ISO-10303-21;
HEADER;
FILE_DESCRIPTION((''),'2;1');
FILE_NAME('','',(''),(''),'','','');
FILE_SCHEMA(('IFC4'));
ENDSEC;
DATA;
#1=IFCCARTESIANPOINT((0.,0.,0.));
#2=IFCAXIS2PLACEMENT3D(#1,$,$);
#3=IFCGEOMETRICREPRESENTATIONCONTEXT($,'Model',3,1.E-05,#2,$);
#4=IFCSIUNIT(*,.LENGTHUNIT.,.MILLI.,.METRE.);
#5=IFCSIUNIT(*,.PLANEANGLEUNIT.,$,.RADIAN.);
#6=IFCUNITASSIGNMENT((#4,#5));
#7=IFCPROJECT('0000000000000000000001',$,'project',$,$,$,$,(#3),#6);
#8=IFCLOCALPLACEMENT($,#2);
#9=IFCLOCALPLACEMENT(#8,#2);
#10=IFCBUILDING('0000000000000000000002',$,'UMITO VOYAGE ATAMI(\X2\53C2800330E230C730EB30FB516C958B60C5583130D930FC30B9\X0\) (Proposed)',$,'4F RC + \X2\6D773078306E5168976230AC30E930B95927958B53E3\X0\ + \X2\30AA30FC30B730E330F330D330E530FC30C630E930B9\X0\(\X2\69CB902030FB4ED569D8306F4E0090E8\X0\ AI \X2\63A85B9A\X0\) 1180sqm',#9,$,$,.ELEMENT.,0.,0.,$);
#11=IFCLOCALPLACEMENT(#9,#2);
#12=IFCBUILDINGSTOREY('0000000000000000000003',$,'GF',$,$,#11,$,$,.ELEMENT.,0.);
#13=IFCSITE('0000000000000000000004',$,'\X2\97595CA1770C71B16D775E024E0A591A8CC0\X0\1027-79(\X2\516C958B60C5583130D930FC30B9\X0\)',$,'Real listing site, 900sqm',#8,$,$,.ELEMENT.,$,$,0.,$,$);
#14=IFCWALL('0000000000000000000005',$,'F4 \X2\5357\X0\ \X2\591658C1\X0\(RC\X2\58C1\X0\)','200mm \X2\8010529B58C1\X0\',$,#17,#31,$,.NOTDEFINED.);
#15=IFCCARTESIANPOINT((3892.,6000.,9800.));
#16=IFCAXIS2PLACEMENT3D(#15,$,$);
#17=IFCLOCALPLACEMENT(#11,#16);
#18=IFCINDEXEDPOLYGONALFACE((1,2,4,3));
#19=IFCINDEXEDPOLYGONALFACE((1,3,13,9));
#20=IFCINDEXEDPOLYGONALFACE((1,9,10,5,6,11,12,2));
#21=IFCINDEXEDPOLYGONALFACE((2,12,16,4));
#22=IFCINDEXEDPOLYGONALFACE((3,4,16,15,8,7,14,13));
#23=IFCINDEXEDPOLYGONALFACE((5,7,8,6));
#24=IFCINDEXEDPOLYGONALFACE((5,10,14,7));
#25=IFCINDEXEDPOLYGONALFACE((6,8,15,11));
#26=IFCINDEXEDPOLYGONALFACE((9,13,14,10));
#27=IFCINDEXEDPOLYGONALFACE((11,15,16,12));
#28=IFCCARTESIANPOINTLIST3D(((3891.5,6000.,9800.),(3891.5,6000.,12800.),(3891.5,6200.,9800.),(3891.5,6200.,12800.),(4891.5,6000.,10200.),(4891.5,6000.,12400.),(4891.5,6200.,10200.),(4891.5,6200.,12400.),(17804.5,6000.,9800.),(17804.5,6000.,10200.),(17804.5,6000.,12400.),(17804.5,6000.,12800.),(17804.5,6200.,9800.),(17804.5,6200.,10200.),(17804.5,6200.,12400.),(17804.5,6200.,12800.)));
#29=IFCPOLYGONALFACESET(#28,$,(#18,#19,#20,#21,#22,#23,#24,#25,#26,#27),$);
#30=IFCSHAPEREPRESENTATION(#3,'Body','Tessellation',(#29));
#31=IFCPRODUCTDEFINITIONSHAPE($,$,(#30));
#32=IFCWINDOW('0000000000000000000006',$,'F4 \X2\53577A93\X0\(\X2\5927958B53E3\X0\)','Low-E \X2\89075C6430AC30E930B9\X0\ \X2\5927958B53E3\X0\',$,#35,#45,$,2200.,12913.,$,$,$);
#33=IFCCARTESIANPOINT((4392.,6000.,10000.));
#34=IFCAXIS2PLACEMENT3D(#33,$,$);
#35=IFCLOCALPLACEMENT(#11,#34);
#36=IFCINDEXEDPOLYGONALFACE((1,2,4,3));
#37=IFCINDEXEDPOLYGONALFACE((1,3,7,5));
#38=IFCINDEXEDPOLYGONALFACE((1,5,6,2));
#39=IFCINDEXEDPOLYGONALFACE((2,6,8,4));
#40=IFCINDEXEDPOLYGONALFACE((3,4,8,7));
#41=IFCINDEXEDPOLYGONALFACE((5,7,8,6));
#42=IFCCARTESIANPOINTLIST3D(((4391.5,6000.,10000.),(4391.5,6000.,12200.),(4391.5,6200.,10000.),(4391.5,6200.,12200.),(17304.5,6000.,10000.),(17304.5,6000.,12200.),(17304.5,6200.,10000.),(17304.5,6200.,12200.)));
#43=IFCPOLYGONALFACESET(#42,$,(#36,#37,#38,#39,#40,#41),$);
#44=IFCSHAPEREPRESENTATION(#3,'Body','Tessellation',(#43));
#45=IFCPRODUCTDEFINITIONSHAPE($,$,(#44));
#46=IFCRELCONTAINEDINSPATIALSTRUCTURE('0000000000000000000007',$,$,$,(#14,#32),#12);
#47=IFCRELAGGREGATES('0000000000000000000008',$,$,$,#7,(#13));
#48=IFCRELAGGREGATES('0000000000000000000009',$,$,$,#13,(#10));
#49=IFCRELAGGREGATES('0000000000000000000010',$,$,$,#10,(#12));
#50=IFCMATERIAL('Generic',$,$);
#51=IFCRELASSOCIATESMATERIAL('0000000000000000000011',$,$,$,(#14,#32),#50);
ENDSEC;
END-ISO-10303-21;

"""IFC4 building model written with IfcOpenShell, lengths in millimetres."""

from ifc_helpers import new_model, si_unit, frame, frame_2d, origin, place, context, project, spatial, rectangle, extrude, material, element, fill, save


model = new_model("IFC4")

# Units and contexts
model_context = context("Model", 3, precision=1e-05, world=origin())
ifc_project = project(units=[si_unit("LENGTHUNIT", "METRE", prefix="MILLI"), si_unit("PLANEANGLEUNIT", "RADIAN")], contexts=[model_context])

# Site, building, storey
site_placement = place(None, origin())
site = spatial("IfcSite", under=ifc_project, at=site_placement, Name="静岡県熱海市上多賀1027-79(公開情報ベース)", ObjectType="Real listing site, 900sqm", CompositionType="ELEMENT", RefElevation=0.0)
building_placement = place(site_placement, origin())
building = spatial("IfcBuilding", under=site, at=building_placement, Name="UMITO VOYAGE ATAMI(参考モデル・公開情報ベース) (Proposed)", ObjectType="4F RC + 海への全面ガラス大開口 + オーシャンビューテラス(構造・仕様は一部 AI 推定) 1180sqm", CompositionType="ELEMENT", ElevationOfRefHeight=0.0, ElevationOfTerrain=0.0)
storey_placement = place(building_placement, origin())
storey = spatial("IfcBuildingStorey", under=building, at=storey_placement, Name="GF", CompositionType="ELEMENT", Elevation=0.0)

# Shared definitions
ifc_material_1 = material(Name="Generic")

# Wall, opening, window
wall_1_placement = place(storey_placement, frame((3892.0, 6000.0, 9800.0)))
wall_1 = element("IfcWall", 1, at=wall_1_placement, inside=storey, material=ifc_material_1, Name="F4 南 外壁(RC壁)", Description="200mm 耐力壁", PredefinedType="NOTDEFINED", context=model_context, shape_type="SweptSolid", body=[
    extrude(rectangle(XDim=13913.0, YDim=200.0, at=frame_2d((6956.0, 100.0))), frame((3892.0, 6000.0, 9800.0)), (0.0, 0.0, 1.0), 3000.0),
])
opening_1_placement = place(storey_placement, frame((4392.0, 6000.0, 10000.0)))
opening_1 = element("IfcOpeningElement", 2, at=opening_1_placement, cuts=wall_1, PredefinedType="NOTDEFINED", context=model_context, shape_type="SweptSolid", body=[
    extrude(rectangle(XDim=12913.0, YDim=200.0, at=frame_2d((6456.0, 100.0))), frame((4392.0, 6000.0, 10000.0)), (0.0, 0.0, 1.0), 2200.0),
])
window_1_placement = place(storey_placement, frame((4392.0, 6000.0, 10000.0)))
window_1 = element("IfcWindow", 3, at=window_1_placement, inside=storey, material=ifc_material_1, Name="F4 南窓(大開口)", Description="Low-E 複層ガラス 大開口", OverallHeight=2200.0, OverallWidth=12913.0, context=model_context, shape_type="SweptSolid", body=[
    extrude(rectangle(XDim=12913.0, YDim=200.0, at=frame_2d((6456.0, 100.0))), frame((4392.0, 6000.0, 10000.0)), (0.0, 0.0, 1.0), 2200.0),
])
fill(opening_1, window_1)

save(model, "model.ifc")
